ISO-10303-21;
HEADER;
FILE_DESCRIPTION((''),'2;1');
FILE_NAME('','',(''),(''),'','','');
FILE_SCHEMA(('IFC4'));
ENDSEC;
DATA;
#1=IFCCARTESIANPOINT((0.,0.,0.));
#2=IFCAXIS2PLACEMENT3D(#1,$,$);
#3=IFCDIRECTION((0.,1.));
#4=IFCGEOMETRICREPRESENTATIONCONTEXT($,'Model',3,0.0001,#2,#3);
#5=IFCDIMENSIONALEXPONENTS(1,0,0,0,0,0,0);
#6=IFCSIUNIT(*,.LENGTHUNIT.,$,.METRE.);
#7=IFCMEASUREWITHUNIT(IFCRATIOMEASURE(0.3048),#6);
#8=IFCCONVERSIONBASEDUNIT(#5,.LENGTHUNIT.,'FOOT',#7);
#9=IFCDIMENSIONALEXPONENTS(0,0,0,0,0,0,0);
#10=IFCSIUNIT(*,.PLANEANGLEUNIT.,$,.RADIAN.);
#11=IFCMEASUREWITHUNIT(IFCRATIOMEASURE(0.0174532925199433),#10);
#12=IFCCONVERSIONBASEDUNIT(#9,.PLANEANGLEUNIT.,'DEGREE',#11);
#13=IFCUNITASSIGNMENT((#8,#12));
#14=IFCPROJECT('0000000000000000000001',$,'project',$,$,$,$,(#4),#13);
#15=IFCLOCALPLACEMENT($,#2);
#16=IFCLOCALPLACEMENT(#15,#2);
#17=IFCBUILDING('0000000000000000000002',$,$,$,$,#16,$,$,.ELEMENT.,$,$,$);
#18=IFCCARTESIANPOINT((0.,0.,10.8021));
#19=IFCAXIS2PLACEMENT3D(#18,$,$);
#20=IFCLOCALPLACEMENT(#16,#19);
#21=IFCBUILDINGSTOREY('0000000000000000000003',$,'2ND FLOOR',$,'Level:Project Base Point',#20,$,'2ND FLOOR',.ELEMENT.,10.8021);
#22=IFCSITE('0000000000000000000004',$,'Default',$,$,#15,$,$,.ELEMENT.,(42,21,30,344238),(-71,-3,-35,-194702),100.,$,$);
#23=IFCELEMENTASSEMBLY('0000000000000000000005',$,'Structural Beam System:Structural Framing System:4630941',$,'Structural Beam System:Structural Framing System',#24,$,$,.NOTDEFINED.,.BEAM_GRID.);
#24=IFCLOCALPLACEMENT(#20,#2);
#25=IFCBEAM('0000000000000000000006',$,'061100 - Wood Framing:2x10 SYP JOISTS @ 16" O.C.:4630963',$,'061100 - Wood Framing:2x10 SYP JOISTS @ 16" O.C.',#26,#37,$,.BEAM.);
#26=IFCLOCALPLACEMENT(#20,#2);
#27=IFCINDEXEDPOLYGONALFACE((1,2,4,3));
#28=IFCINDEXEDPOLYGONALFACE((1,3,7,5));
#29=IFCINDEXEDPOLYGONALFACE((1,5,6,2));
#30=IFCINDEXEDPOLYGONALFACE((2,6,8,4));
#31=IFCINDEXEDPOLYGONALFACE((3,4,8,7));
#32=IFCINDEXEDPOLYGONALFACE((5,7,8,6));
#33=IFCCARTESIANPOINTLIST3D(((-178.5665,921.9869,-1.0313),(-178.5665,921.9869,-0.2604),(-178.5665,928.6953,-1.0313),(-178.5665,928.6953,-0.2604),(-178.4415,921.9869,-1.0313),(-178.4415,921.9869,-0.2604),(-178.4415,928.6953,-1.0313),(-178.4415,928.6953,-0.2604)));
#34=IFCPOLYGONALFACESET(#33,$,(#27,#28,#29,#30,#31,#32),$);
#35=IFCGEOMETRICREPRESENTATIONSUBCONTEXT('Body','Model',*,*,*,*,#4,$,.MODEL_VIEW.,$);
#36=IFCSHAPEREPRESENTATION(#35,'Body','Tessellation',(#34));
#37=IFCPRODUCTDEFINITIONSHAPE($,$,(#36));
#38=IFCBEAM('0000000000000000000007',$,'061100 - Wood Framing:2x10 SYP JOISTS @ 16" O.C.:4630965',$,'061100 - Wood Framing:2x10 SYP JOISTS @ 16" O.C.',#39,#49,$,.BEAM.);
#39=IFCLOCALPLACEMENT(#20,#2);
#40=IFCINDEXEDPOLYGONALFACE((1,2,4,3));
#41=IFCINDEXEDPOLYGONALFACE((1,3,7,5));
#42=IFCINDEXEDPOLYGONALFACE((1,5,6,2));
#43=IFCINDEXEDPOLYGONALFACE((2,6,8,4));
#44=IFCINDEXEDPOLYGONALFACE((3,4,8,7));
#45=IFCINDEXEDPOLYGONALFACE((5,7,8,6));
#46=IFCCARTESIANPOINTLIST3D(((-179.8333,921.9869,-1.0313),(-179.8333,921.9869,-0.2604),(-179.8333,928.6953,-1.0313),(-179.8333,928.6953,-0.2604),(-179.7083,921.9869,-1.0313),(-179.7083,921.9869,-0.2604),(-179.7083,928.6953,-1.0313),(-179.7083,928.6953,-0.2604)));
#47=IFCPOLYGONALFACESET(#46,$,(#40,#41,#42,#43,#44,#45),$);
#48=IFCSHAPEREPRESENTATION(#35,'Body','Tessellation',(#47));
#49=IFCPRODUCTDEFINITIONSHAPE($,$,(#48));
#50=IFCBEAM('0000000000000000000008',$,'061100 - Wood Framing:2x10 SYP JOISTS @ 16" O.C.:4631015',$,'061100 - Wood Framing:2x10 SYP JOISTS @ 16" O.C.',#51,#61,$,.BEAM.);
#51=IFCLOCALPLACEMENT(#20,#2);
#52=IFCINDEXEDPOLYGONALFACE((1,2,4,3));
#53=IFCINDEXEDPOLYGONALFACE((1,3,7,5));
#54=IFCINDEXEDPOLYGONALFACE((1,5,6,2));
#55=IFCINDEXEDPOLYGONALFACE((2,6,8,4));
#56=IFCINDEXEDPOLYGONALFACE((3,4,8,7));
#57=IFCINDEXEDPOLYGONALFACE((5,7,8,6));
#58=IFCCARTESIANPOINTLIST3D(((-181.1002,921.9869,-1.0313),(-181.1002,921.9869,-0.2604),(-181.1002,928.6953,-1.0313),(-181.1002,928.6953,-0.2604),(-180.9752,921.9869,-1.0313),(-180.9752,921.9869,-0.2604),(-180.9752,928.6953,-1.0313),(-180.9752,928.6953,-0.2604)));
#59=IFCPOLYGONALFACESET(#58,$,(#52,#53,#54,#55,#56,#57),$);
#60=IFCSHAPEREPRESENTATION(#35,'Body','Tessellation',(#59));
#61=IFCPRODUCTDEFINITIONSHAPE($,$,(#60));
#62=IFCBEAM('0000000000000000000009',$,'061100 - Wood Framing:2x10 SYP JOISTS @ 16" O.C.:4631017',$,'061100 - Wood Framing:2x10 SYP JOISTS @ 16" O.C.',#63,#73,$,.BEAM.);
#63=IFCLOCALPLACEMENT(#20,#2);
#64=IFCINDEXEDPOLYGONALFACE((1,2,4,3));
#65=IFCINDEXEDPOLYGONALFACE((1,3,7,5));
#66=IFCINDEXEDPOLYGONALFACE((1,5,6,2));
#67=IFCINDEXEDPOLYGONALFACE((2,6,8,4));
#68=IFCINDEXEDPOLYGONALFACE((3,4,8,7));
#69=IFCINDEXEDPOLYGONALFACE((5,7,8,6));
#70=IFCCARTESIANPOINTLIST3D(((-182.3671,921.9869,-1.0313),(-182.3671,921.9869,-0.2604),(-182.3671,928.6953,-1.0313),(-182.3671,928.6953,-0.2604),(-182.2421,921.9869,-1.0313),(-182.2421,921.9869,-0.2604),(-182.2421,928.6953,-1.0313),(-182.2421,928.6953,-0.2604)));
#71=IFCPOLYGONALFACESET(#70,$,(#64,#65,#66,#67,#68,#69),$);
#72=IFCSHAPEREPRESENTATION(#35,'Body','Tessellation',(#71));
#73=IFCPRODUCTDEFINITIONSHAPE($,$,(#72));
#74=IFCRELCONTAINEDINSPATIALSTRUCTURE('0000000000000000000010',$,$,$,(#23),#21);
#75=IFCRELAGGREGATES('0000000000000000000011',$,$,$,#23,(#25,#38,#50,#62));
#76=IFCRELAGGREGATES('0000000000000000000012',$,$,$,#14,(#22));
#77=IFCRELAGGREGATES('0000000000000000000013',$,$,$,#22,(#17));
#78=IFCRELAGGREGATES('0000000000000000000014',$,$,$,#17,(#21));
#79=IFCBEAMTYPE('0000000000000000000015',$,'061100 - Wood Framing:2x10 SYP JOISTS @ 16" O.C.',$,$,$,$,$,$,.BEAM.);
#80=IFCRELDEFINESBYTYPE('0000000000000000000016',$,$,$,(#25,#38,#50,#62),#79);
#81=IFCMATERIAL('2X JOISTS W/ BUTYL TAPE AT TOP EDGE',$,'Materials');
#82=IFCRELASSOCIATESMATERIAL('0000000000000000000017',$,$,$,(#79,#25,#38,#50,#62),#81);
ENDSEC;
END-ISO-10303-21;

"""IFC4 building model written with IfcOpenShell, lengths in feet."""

from ifc_helpers import new_model, entity, si_unit, converted_unit, direction, frame, frame_2d, origin, place, context, subcontext, project, spatial, rectangle, extrude, source, transform, mapped, material, material_profile, profile_set, profile_usage, type_object, type_shapes, element, aggregate, save


model = new_model("IFC4")

# Units and contexts
model_context = context("Model", 3, precision=0.0001, world=origin(), true_north=direction((0.0, 1.0)))
body_context = subcontext(model_context, "Body", "Model", "MODEL_VIEW")
ifc_project = project(units=[converted_unit("LENGTHUNIT", "FOOT", entity("IfcRatioMeasure", 0.3048), si_unit("LENGTHUNIT", "METRE"), dimensions=[1, 0, 0, 0, 0, 0, 0]), converted_unit("PLANEANGLEUNIT", "DEGREE", entity("IfcRatioMeasure", 0.0174532925199433), si_unit("PLANEANGLEUNIT", "RADIAN"), dimensions=[0, 0, 0, 0, 0, 0, 0])], contexts=[model_context])

# Site, building, storey
site_placement = place(None, origin())
site = spatial("IfcSite", under=ifc_project, at=site_placement, Name="Default", CompositionType="ELEMENT", RefLatitude=(42, 21, 30, 344238), RefLongitude=(-71, -3, -35, -194702), RefElevation=100.0)
building_placement = place(site_placement, origin())
building = spatial("IfcBuilding", under=site, at=building_placement, CompositionType="ELEMENT")
storey_placement = place(building_placement, frame((0.0, 0.0, 10.8021)))
storey = spatial("IfcBuildingStorey", under=building, at=storey_placement, Name="2ND FLOOR", ObjectType="Level:Project Base Point", LongName="2ND FLOOR", CompositionType="ELEMENT", Elevation=10.8021)

# Element assembly, beams
ifc_material_1 = material(Name="2X JOISTS W/ BUTYL TAPE AT TOP EDGE", Category="Materials")
ifc_material_profile_1 = material_profile(ifc_material_1, rectangle(XDim=0.7708, YDim=0.125, at=frame_2d((0.0, 0.0), x_axis=(1.0, 0.0))), Name="2x10 SYP JOISTS @ 16\" O.C.")
ifc_profile_set_1 = profile_set([ifc_material_profile_1], Name="2x10 SYP JOISTS @ 16\" O.C.")
beam_type_1 = type_object("IfcBeamType", Name="061100 - Wood Framing:2x10 SYP JOISTS @ 16\" O.C.", PredefinedType="BEAM", material=ifc_profile_set_1)
shared_shape_1 = source(origin(), body_context, "Body", "SweptSolid", [
    extrude(rectangle(XDim=0.7708, YDim=0.125, at=frame_2d((0.0, 0.0), x_axis=(1.0, 0.0))), frame((-3.3542, 0.0, 0.0), z_axis=(1.0, 0.0, 0.0), x_axis=(0.0, 0.0, -1.0)), (0.0, 0.0, 1.0), 6.7083),
])
type_shapes(beam_type_1, [shared_shape_1])
assembly_1_placement = place(storey_placement, origin())
assembly_1 = element("IfcElementAssembly", 1, at=assembly_1_placement, inside=storey, Name="Structural Beam System:Structural Framing System:4630941", ObjectType="Structural Beam System:Structural Framing System", AssemblyPlace="NOTDEFINED", PredefinedType="BEAM_GRID")
ifc_profile_usage_1 = profile_usage(ifc_profile_set_1, cardinal=8)
beam_1_placement = place(assembly_1_placement, frame((-178.504, 925.3411, -0.6458), z_axis=(0.0, 0.0, 1.0), x_axis=(0.0, 1.0, 0.0)))
beam_1 = element("IfcBeam", 2, at=beam_1_placement, type_object=beam_type_1, material=ifc_profile_usage_1, Name="061100 - Wood Framing:2x10 SYP JOISTS @ 16\" O.C.:4630963", ObjectType="061100 - Wood Framing:2x10 SYP JOISTS @ 16\" O.C.", PredefinedType="BEAM", context=body_context, shape_type="MappedRepresentation", body=[
    mapped(shared_shape_1, transform((0.0, 0.0, 0.0), scale=1.0)),
])
ifc_profile_usage_2 = profile_usage(ifc_profile_set_1, cardinal=8)
beam_2_placement = place(assembly_1_placement, frame((-179.7708, 925.3411, -0.6458), z_axis=(0.0, 0.0, 1.0), x_axis=(0.0, 1.0, 0.0)))
beam_2 = element("IfcBeam", 3, at=beam_2_placement, type_object=beam_type_1, material=ifc_profile_usage_2, Name="061100 - Wood Framing:2x10 SYP JOISTS @ 16\" O.C.:4630965", ObjectType="061100 - Wood Framing:2x10 SYP JOISTS @ 16\" O.C.", PredefinedType="BEAM", context=body_context, shape_type="MappedRepresentation", body=[
    mapped(shared_shape_1, transform((0.0, 0.0, 0.0), scale=1.0)),
])
ifc_profile_usage_3 = profile_usage(ifc_profile_set_1, cardinal=8)
beam_3_placement = place(assembly_1_placement, frame((-181.0377, 925.3411, -0.6458), z_axis=(0.0, 0.0, 1.0), x_axis=(0.0, 1.0, 0.0)))
beam_3 = element("IfcBeam", 4, at=beam_3_placement, type_object=beam_type_1, material=ifc_profile_usage_3, Name="061100 - Wood Framing:2x10 SYP JOISTS @ 16\" O.C.:4631015", ObjectType="061100 - Wood Framing:2x10 SYP JOISTS @ 16\" O.C.", PredefinedType="BEAM", context=body_context, shape_type="MappedRepresentation", body=[
    mapped(shared_shape_1, transform((0.0, 0.0, 0.0), scale=1.0)),
])
ifc_profile_usage_4 = profile_usage(ifc_profile_set_1, cardinal=8)
beam_4_placement = place(assembly_1_placement, frame((-182.3046, 925.3411, -0.6458), z_axis=(0.0, 0.0, 1.0), x_axis=(0.0, 1.0, 0.0)))
beam_4 = element("IfcBeam", 5, at=beam_4_placement, type_object=beam_type_1, material=ifc_profile_usage_4, Name="061100 - Wood Framing:2x10 SYP JOISTS @ 16\" O.C.:4631017", ObjectType="061100 - Wood Framing:2x10 SYP JOISTS @ 16\" O.C.", PredefinedType="BEAM", context=body_context, shape_type="MappedRepresentation", body=[
    mapped(shared_shape_1, transform((0.0, 0.0, 0.0), scale=1.0)),
])
aggregate(assembly_1, [beam_1, beam_2, beam_3, beam_4])

save(model, "model.ifc")
